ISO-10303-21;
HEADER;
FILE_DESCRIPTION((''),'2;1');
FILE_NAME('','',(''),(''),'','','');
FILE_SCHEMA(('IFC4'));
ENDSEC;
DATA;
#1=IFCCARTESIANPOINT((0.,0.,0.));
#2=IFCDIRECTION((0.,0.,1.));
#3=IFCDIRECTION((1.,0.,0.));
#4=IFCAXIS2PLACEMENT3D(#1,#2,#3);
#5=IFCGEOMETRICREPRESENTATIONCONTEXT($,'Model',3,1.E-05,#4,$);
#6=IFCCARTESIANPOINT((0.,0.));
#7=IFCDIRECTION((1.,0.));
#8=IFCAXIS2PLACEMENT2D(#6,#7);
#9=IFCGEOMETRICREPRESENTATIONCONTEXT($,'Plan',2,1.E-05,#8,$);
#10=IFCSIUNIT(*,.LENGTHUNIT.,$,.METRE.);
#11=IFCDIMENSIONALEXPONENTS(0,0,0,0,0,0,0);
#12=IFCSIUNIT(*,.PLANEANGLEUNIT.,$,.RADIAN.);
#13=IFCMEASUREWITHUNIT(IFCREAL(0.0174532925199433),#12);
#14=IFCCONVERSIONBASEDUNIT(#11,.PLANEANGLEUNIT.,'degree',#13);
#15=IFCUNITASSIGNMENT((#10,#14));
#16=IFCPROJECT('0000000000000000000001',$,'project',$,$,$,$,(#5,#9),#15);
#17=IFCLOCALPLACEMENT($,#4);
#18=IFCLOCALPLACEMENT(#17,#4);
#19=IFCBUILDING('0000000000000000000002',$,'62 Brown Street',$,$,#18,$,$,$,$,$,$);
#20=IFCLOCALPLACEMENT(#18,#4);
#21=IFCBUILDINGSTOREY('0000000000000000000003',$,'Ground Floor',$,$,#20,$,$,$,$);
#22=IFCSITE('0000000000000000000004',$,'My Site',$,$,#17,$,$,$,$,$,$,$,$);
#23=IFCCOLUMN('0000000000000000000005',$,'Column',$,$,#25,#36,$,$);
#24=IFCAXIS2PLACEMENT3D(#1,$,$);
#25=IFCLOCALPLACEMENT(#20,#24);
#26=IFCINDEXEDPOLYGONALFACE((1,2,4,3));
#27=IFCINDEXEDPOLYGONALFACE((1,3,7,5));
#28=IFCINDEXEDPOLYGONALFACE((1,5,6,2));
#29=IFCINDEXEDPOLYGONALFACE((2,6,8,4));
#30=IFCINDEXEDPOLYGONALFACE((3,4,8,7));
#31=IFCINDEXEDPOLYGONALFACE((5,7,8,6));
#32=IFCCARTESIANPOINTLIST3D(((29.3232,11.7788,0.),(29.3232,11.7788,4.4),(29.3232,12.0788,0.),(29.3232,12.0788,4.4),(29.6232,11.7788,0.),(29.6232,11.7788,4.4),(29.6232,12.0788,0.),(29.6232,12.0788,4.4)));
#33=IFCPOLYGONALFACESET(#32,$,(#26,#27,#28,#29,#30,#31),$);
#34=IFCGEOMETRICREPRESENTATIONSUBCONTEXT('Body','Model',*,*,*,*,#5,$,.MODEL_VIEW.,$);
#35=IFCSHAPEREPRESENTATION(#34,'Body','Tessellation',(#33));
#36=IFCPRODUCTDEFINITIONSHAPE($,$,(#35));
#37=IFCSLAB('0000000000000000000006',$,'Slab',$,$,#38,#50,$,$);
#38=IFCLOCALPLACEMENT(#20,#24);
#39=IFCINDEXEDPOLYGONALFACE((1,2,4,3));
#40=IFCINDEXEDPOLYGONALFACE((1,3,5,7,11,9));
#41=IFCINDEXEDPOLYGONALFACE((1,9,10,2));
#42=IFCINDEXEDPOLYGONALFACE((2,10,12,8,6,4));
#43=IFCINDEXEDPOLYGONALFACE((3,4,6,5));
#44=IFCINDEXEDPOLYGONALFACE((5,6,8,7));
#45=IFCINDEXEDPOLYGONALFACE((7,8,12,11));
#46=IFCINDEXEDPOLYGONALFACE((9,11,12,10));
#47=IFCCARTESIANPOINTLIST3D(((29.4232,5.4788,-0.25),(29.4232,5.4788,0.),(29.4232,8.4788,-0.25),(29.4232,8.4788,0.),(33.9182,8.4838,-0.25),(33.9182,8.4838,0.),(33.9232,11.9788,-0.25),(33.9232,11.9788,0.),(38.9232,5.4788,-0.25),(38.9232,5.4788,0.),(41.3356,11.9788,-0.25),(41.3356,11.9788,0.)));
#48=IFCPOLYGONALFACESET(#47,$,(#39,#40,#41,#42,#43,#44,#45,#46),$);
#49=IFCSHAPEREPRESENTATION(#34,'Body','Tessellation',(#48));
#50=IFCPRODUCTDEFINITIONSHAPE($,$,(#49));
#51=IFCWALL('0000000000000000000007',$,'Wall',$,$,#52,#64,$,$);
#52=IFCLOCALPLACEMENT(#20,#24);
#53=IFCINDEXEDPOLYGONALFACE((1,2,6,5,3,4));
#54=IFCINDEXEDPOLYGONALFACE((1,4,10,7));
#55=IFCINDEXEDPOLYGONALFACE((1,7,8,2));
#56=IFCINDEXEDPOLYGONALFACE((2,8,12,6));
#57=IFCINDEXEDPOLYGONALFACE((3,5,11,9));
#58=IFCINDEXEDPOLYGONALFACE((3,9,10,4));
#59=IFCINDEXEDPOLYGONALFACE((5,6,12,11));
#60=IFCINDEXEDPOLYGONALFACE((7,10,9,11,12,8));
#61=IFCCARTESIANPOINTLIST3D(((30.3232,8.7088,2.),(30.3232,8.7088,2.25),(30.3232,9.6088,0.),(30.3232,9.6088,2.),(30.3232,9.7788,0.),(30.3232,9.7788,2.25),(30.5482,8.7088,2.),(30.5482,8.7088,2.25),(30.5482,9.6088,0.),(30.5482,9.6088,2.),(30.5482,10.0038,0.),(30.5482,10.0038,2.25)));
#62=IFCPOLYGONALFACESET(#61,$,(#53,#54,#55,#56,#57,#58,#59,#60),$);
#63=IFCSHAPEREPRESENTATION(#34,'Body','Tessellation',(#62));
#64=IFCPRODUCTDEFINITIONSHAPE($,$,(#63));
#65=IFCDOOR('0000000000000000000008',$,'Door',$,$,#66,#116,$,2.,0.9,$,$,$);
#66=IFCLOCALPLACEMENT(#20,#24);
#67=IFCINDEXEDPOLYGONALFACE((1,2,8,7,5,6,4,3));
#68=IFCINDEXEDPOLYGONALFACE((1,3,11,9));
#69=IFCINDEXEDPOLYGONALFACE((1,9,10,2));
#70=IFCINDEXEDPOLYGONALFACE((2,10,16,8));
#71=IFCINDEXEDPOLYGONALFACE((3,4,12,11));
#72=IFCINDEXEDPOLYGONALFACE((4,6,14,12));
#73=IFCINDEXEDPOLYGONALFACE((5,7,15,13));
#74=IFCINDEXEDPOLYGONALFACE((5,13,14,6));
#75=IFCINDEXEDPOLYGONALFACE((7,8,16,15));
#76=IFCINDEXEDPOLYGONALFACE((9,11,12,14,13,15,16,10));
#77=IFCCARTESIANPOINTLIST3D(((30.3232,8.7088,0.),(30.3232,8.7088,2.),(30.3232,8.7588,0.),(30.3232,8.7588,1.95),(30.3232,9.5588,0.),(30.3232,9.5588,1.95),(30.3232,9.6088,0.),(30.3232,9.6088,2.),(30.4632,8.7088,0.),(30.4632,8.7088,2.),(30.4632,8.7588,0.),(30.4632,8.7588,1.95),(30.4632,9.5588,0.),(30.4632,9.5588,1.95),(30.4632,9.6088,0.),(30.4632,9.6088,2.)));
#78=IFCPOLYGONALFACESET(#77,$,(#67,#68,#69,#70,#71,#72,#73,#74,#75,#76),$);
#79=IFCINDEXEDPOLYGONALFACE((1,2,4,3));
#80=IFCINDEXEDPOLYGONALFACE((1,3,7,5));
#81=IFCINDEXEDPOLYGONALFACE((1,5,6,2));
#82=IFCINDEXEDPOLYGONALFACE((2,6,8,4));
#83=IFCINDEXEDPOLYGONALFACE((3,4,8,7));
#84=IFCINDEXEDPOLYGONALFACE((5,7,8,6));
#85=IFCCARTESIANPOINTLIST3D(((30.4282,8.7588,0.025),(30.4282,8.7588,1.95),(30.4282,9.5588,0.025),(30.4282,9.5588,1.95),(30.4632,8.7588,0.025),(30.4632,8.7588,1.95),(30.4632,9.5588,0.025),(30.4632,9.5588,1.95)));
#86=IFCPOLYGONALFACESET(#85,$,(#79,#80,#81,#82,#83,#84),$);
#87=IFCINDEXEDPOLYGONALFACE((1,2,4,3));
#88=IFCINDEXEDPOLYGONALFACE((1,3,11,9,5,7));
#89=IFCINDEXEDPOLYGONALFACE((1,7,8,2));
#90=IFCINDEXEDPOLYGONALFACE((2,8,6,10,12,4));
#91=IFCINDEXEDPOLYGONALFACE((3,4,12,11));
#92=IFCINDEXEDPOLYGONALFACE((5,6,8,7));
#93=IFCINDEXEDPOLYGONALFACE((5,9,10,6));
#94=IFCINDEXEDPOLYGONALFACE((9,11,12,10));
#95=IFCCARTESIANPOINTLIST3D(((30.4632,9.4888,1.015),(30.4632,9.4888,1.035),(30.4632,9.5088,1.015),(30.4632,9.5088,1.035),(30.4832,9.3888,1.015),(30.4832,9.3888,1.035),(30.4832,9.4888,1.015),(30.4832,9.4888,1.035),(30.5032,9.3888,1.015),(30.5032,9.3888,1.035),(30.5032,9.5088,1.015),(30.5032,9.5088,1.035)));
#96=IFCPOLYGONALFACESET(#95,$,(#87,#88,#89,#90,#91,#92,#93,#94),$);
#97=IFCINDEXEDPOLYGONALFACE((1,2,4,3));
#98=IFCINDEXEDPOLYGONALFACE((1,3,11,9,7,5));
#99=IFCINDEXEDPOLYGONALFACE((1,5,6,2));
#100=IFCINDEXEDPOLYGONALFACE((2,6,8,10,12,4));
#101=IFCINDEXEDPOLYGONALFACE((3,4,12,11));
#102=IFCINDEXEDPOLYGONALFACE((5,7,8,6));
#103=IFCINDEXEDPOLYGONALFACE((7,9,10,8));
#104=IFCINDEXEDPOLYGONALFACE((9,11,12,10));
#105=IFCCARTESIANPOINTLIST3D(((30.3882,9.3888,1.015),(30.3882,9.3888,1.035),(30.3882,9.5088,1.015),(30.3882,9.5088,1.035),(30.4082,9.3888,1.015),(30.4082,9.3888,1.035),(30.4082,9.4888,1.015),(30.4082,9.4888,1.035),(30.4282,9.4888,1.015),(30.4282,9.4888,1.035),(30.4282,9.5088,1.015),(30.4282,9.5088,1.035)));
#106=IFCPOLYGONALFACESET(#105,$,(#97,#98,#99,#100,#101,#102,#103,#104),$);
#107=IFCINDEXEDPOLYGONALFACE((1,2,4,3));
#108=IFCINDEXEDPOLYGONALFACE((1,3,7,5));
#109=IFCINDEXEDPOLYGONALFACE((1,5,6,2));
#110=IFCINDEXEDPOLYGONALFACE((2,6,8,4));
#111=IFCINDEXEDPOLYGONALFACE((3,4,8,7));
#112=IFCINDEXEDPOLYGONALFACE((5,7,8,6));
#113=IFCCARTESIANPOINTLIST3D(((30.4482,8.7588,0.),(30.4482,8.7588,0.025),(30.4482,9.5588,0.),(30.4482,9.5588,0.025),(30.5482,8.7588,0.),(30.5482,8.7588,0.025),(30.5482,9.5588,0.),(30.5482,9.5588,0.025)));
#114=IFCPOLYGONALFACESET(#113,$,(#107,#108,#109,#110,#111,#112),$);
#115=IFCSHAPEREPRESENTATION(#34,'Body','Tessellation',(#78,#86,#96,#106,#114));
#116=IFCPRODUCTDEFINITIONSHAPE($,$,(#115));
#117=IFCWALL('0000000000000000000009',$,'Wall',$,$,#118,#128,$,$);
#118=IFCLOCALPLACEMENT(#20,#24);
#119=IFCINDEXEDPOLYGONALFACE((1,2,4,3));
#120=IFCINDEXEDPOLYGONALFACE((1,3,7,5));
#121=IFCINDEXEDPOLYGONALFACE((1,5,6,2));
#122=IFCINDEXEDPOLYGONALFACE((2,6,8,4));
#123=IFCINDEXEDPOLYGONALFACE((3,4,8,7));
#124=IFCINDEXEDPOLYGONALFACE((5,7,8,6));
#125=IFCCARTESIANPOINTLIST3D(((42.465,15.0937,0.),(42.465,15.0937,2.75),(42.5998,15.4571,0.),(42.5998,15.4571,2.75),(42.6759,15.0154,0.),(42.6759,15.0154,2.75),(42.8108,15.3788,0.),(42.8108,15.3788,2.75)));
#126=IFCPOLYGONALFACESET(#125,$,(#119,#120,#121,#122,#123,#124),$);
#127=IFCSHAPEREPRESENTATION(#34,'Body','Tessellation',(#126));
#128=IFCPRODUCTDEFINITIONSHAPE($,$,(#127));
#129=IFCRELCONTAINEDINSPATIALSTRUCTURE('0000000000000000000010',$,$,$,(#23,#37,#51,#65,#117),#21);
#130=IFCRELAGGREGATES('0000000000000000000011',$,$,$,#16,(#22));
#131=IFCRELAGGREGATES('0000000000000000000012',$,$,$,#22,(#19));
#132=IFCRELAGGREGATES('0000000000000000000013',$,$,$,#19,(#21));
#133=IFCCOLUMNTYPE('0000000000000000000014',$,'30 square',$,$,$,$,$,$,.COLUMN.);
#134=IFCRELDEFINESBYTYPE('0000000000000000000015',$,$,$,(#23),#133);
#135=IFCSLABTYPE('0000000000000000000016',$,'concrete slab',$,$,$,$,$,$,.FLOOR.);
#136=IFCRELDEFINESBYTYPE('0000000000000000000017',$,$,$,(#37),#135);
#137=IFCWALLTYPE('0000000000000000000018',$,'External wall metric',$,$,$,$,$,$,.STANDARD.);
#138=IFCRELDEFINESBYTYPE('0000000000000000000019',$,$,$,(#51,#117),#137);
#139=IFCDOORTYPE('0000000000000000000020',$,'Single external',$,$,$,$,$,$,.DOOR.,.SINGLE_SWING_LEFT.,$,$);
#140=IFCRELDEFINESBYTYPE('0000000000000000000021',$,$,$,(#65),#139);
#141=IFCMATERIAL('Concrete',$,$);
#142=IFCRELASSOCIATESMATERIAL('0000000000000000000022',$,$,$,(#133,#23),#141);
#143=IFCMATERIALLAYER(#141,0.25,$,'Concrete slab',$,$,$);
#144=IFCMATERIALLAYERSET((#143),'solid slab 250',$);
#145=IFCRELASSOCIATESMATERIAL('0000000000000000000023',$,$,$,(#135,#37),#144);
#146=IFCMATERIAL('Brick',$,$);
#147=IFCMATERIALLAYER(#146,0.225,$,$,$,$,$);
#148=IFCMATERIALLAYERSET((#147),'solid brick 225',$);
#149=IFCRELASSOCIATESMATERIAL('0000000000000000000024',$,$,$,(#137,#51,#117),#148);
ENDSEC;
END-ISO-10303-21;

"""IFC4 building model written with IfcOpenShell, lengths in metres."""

from ifc_helpers import new_model, entity, si_unit, converted_unit, frame, origin_with_axes, origin_2d_with_axis, place, context, subcontext, project, spatial, line, indexed_curve, rectangle, outline, extrude, clip, halfspace, shape, source, transform, mapped, material, layer, layer_set, layer_usage, material_profile, profile_set, profile_usage, type_object, type_shapes, element, fill, save


model = new_model("IFC4")

# Units and contexts
model_context = context("Model", 3, precision=1e-05, world=origin_with_axes())
plan_context = context("Plan", 2, precision=1e-05, world=origin_2d_with_axis())
body_context_1 = subcontext(model_context, "Body", "Model", "MODEL_VIEW")
body_context_2 = subcontext(plan_context, "Body", "Plan", "PLAN_VIEW")
ifc_project = project(units=[si_unit("LENGTHUNIT", "METRE"), converted_unit("PLANEANGLEUNIT", "degree", entity("IfcReal", 0.0174532925199433), si_unit("PLANEANGLEUNIT", "RADIAN"), dimensions=[0, 0, 0, 0, 0, 0, 0])], contexts=[model_context, plan_context])

# Site, building, storey
site_placement = place(None, origin_with_axes())
site = spatial("IfcSite", under=ifc_project, at=site_placement, Name="My Site")
building_placement = place(site_placement, origin_with_axes())
building = spatial("IfcBuilding", under=site, at=building_placement, Name="62 Brown Street")
storey_placement = place(building_placement, origin_with_axes())
storey = spatial("IfcBuildingStorey", under=building, at=storey_placement, Name="Ground Floor")

# Column
ifc_material_1 = material(Name="Concrete")
ifc_material_profile = material_profile(ifc_material_1, rectangle(XDim=0.3, YDim=0.3))
ifc_profile_set = profile_set([ifc_material_profile])
ifc_profile_usage = profile_usage(ifc_profile_set, cardinal=5)
column_type = type_object("IfcColumnType", Name="30 square", PredefinedType="COLUMN", material=ifc_profile_set)
column_placement = place(storey_placement, frame((29.4732, 11.9288, 0.0), z_axis=(0.0, 0.0, 1.0), x_axis=(1.0, 0.0, 0.0)))
element("IfcColumn", 1, at=column_placement, inside=storey, type_object=column_type, material=ifc_profile_usage, Name="Column", context=body_context_1, shape_type="SweptSolid", body=[
    extrude(rectangle(XDim=0.3, YDim=0.3), origin_with_axes(), (0.0, 0.0, 1.0), 4.4),
])

# Slab
ifc_layer_1 = layer(ifc_material_1, 0.25, Name="Concrete slab")
ifc_layer_set_1 = layer_set([ifc_layer_1], Name="solid slab 250")
ifc_layer_usage_1 = layer_usage(ifc_layer_set_1, "AXIS3", "POSITIVE", 0.0)
slab_type = type_object("IfcSlabType", Name="concrete slab", PredefinedType="FLOOR", material=ifc_layer_set_1)
slab_1_placement = place(storey_placement, frame((29.4232, 5.4788, -0.25), z_axis=(0.0, 0.0, 1.0), x_axis=(1.0, 0.0, 0.0)))
element("IfcSlab", 2, at=slab_1_placement, inside=storey, type_object=slab_type, material=ifc_layer_usage_1, Name="Slab", context=body_context_1, shape_type="SweptSolid", body=[
    extrude(outline(indexed_curve([(0.0, 0.0), (9.5, 0.0), (11.9124, 6.5), (0.0, 3.0), (4.5, 6.5), (4.495, 3.005)], segments=[line(1, 2), line(2, 3), line(3, 5), line(5, 6), line(6, 4), line(4, 1)], self_intersect=False)), None, (0.0, 0.0, 1.0), 0.25),
])

# Shared definitions
ifc_material_2 = material(Name="Brick")
ifc_layer_2 = layer(ifc_material_2, 0.225)
ifc_layer_set_2 = layer_set([ifc_layer_2], Name="solid brick 225")
wall_type_1 = type_object("IfcWallType", Name="External wall metric", PredefinedType="STANDARD", material=ifc_layer_set_2)

# Wall, opening, door
ifc_layer_usage_2 = layer_usage(ifc_layer_set_2, "AXIS2", "POSITIVE", 0.0)
wall_1_placement = place(storey_placement, frame((30.5482, 8.7088, 0.0), z_axis=(0.0, 0.0, 1.0), x_axis=(0.0, 1.0, 0.0)))
wall_1 = element("IfcWall", 3, at=wall_1_placement, inside=storey, type_object=wall_type_1, material=ifc_layer_usage_2, Name="Wall", context=body_context_1, shape_type="Clipping", body=[
    clip(extrude(outline(indexed_curve([(0.0, 0.0), (0.0, 0.225), (1.295, 0.225), (1.295, 0.0), (0.0, 0.0)], self_intersect=False)), origin_with_axes(), (0.0, 0.0, 1.0), 2.25), halfspace(frame((1.295, 0.0, 0.0), z_axis=(0.506251, 0.506251, 0.0), x_axis=(-0.225, 0.225, 0.0)), False)),
])
shared_shape_1 = source(origin_with_axes(), body_context_1, "Body", "SweptSolid", [
    extrude(outline(indexed_curve([(0.0, 0.0), (0.9, 0.0), (0.9, 2.0), (0.0, 2.0)], segments=[line(1, 2, 3, 4, 1)])), frame((0.0, -0.6, 0.0), z_axis=(0.0, -1.0, 0.0), x_axis=(1.0, 0.0, 0.0)), (0.0, 0.0, -1.0), 1.2),
])
opening_1_placement = place(wall_1_placement, frame((0.0, 0.0, 0.0), z_axis=(0.0, 0.0, 1.0), x_axis=(1.0, 0.0, 0.0)))
opening_1 = element("IfcOpeningElement", 4, at=opening_1_placement, cuts=wall_1, PredefinedType="OPENING", context=body_context_1, shape_type="MappedRepresentation", body=[
    mapped(shared_shape_1, transform((0.0, 0.0, 0.0), x_axis=(1.0, 0.0, 0.0), y_axis=(0.0, 1.0, 0.0), z_axis=(0.0, 0.0, 1.0), scale=1.0)),
])
door_type_1 = type_object("IfcDoorType", Name="Single external", OperationType="SINGLE_SWING_LEFT", PredefinedType="DOOR")
shared_shape_2 = source(origin_with_axes(), body_context_1, "Body", "SweptSolid", [
    extrude(outline(indexed_curve([(0.0, 0.0), (0.0, 2.0), (0.9, 2.0), (0.9, 0.0), (0.85, 0.0), (0.85, 1.95), (0.05, 1.95), (0.05, 0.0)], segments=[line(1, 2, 3, 4, 5, 6, 7, 8, 1)])), frame((0.0, 0.085, 0.0), z_axis=(0.0, -1.0, 0.0), x_axis=(1.0, 0.0, 0.0)), (0.0, 0.0, -1.0), 0.14),
    extrude(outline(indexed_curve([(0.0, 0.0), (0.8, 0.0), (0.8, 0.035), (0.0, 0.035)], segments=[line(1, 2, 3, 4, 1)])), frame((0.05, 0.085, 0.025), z_axis=(0.0, 0.0, 1.0), x_axis=(1.0, 0.0, 0.0)), (0.0, 0.0, 1.0), 1.925),
    extrude(outline(indexed_curve([(0.0, 0.0), (0.0, -0.04), (-0.12, -0.04), (-0.12, -0.02), (-0.02, -0.02), (-0.02, 0.0)], segments=[line(1, 2, 3, 4, 5, 6, 1)])), frame((0.8, 0.085, 1.015), z_axis=(0.0, 0.0, 1.0), x_axis=(1.0, 0.0, 0.0)), (0.0, 0.0, 1.0), 0.02),
    extrude(outline(indexed_curve([(0.0, 0.0), (0.0, 0.04), (-0.12, 0.04), (-0.12, 0.02), (-0.02, 0.02), (-0.02, 0.0)], segments=[line(1, 2, 3, 4, 5, 6, 1)])), frame((0.8, 0.12, 1.015), z_axis=(0.0, 0.0, 1.0), x_axis=(1.0, 0.0, 0.0)), (0.0, 0.0, 1.0), 0.02),
    extrude(outline(indexed_curve([(0.0, 0.0), (0.8, 0.0), (0.8, 0.1), (0.0, 0.1)], segments=[line(1, 2, 3, 4, 1)])), frame((0.05, 0.0, 0.0), z_axis=(0.0, 0.0, 1.0), x_axis=(1.0, 0.0, 0.0)), (0.0, 0.0, 1.0), 0.025),
])
shared_shape_3 = source(origin_with_axes(), body_context_2, "Body", "Curve2D", [
    entity("IfcIndexedPolyCurve", entity("IfcCartesianPointList2D", [[0.0, 0.085], [0.05, 0.085], [0.05, 0.225], [0.0, 0.225]]), [entity("IfcLineIndex", [1, 2, 3, 4, 1])]),
    entity("IfcIndexedPolyCurve", entity("IfcCartesianPointList2D", [[0.9, 0.085], [0.85, 0.085], [0.85, 0.225], [0.9, 0.225]]), [entity("IfcLineIndex", [1, 2, 3, 4, 1])]),
    entity("IfcTrimmedCurve", entity("IfcEllipse", entity("IfcAxis2Placement2D", entity("IfcCartesianPoint", [0.085, 0.225]), entity("IfcDirection", [1.0, 0.0])), 0.765, 0.8), [entity("IfcCartesianPoint", [0.85, 0.225])], [entity("IfcCartesianPoint", [0.085, 1.025])], True, "CARTESIAN"),
    entity("IfcIndexedPolyCurve", entity("IfcCartesianPointList2D", [[0.05, 0.225], [0.085, 0.225], [0.085, 1.025], [0.05, 1.025]]), [entity("IfcLineIndex", [1, 2, 3, 4, 1])]),
])
type_shapes(door_type_1, [shared_shape_2, shared_shape_3])
door_1_placement = place(opening_1_placement, frame((0.0, 0.0, 0.0), z_axis=(0.0, 0.0, 1.0), x_axis=(1.0, 0.0, 0.0)))
door_1 = element("IfcDoor", 5, at=door_1_placement, inside=storey, type_object=door_type_1, Name="Door", OverallHeight=2.0, OverallWidth=0.9, shapes=[
    shape(body_context_1, "Body", "MappedRepresentation", [mapped(shared_shape_2, transform((0.0, 0.0, 0.0), x_axis=(1.0, 0.0, 0.0), y_axis=(0.0, 1.0, 0.0), z_axis=(0.0, 0.0, 1.0), scale=1.0))]),
    shape(body_context_2, "Body", "MappedRepresentation", [mapped(shared_shape_3, transform((0.0, 0.0, 0.0), x_axis=(1.0, 0.0, 0.0), y_axis=(0.0, 1.0, 0.0), z_axis=(0.0, 0.0, 1.0), scale=1.0))]),
])
fill(opening_1, door_1)

# Wall
ifc_layer_usage_3 = layer_usage(ifc_layer_set_2, "AXIS2", "POSITIVE", 0.0)
wall_2_placement = place(storey_placement, frame((42.6759, 15.0154, 0.0), z_axis=(0.0, 0.0, 1.0), x_axis=(0.347944, 0.937515, 0.0)))
element("IfcWall", 6, at=wall_2_placement, inside=storey, type_object=wall_type_1, material=ifc_layer_usage_3, Name="Wall", context=body_context_1, shape_type="SweptSolid", body=[
    extrude(outline(indexed_curve([(0.0, 0.0), (0.0, 0.225), (0.3876, 0.225), (0.3876, 0.0), (0.0, 0.0)], self_intersect=False)), origin_with_axes(), (0.0, 0.0, 1.0), 2.75),
])

save(model, "model.ifc")
